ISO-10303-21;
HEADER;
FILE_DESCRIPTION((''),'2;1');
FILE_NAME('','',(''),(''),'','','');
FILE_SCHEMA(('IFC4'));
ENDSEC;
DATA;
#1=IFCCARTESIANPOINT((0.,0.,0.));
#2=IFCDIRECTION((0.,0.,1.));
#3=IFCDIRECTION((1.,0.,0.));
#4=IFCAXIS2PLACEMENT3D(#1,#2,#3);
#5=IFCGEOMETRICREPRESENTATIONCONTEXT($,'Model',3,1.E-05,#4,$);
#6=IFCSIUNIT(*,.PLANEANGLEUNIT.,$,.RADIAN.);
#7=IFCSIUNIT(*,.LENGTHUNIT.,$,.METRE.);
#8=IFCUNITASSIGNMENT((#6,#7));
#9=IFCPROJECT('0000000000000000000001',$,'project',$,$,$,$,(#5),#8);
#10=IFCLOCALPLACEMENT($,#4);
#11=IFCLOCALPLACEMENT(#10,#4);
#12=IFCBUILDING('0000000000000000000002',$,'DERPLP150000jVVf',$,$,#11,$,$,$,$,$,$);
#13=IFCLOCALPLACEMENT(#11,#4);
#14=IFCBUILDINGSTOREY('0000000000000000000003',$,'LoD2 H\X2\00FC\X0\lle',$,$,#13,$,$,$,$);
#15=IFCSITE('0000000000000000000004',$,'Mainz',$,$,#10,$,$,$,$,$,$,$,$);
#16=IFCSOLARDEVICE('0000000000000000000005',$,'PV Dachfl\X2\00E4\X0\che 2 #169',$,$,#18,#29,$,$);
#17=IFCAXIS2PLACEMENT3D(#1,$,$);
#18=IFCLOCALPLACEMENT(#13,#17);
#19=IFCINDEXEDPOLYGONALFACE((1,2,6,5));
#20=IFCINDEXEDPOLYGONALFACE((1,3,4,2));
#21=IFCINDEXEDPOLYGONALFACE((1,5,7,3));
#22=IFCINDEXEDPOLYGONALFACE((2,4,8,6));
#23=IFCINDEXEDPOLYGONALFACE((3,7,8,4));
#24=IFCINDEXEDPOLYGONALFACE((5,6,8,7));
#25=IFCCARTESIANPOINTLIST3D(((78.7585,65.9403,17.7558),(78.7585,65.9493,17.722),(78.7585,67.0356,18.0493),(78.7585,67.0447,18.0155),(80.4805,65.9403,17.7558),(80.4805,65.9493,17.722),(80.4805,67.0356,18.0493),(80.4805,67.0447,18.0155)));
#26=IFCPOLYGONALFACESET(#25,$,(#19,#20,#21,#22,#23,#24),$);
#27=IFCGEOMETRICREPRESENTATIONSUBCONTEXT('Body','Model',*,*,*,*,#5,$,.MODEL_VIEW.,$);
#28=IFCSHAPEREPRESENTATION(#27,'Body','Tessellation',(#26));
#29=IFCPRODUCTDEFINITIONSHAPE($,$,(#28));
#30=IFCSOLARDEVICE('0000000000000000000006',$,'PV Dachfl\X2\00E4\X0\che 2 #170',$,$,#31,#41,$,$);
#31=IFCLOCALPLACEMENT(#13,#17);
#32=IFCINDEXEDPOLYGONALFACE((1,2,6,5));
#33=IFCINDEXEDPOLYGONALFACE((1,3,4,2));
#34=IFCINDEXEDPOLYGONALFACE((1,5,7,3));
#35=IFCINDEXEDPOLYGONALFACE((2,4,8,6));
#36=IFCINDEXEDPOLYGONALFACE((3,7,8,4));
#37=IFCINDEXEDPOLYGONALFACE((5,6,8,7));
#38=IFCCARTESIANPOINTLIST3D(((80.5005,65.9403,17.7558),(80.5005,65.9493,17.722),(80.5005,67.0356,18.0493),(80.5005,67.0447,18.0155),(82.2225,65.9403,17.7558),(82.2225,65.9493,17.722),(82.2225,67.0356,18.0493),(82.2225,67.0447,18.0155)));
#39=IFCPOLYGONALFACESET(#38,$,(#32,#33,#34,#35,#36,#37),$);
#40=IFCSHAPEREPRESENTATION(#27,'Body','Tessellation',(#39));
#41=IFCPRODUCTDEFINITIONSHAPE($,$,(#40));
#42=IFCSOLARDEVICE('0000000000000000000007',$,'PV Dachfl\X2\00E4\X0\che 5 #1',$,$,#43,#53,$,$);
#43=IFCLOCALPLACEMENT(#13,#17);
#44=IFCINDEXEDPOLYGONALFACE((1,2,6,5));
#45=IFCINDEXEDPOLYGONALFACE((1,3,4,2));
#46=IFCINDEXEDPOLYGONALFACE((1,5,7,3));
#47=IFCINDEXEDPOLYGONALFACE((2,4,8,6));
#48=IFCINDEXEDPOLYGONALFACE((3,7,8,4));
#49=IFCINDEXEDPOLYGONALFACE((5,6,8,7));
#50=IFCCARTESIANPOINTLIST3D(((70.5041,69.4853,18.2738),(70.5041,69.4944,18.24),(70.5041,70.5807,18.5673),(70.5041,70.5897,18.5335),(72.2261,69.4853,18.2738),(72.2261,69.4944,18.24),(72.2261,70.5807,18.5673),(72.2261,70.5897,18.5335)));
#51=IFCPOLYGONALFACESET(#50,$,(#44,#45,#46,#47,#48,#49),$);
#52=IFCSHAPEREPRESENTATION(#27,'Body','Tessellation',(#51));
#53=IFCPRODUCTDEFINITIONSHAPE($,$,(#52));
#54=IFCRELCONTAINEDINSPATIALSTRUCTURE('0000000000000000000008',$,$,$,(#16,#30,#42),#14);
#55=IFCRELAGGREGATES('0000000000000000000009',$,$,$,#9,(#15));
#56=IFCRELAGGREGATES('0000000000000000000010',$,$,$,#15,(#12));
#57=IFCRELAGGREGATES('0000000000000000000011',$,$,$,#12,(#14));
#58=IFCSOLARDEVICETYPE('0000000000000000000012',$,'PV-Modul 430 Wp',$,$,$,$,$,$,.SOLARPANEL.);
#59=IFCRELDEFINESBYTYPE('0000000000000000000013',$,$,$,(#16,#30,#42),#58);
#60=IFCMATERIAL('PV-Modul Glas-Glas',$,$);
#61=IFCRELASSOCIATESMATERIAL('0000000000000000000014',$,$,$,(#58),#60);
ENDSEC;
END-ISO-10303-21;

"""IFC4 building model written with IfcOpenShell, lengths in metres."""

from ifc_helpers import new_model, si_unit, frame, frame_2d, origin, origin_with_axes, place, context, subcontext, project, spatial, rectangle, extrude, source, transform, mapped, material, type_object, type_shapes, element, save


model = new_model("IFC4")

# Units and contexts
model_context = context("Model", 3, precision=1e-05, world=origin_with_axes())
body_context = subcontext(model_context, "Body", "Model", "MODEL_VIEW")
ifc_project = project(units=[si_unit("PLANEANGLEUNIT", "RADIAN"), si_unit("LENGTHUNIT", "METRE")], contexts=[model_context])

# Site, building, storey
site_placement = place(None, origin_with_axes())
site = spatial("IfcSite", under=ifc_project, at=site_placement, Name="Mainz")
building_placement = place(site_placement, origin_with_axes())
building = spatial("IfcBuilding", under=site, at=building_placement, Name="DERPLP150000jVVf")
storey_placement = place(building_placement, origin_with_axes())
storey = spatial("IfcBuildingStorey", under=building, at=storey_placement, Name="LoD2 Hülle")

# Solar devices
ifc_material = material(Name="PV-Modul Glas-Glas")
solar_device_type = type_object("IfcSolarDeviceType", Name="PV-Modul 430 Wp", PredefinedType="SOLARPANEL", material=ifc_material)
shared_shape = source(origin_with_axes(), body_context, "Body", "SweptSolid", [
    extrude(rectangle(XDim=1.722, YDim=1.134, at=frame_2d((0.861, 0.567))), origin(), (0.0, 0.0, 1.0), 0.035),
])
type_shapes(solar_device_type, [shared_shape])
for number, where, z_axis, x_axis, name in (
    (1, (78.7585, 65.9493, 17.722), (0.0, -0.258819, 0.965926), (1.0, 0.0, 0.0), "PV Dachfläche 2 #169"),
    (2, (80.5005, 65.9493, 17.722), (0.0, -0.258819, 0.965926), (1.0, 0.0, 0.0), "PV Dachfläche 2 #170"),
    (3, (70.5041, 69.4944, 18.24), (0.0, -0.258819, 0.965926), (1.0, 0.0, 0.0), "PV Dachfläche 5 #1"),
):
    element("IfcSolarDevice", number, at=place(storey_placement, frame(where, z_axis=z_axis, x_axis=x_axis)), inside=storey, type_object=solar_device_type, Name=name, context=body_context, shape_type="MappedRepresentation", body=[
        mapped(shared_shape, transform((0.0, 0.0, 0.0), x_axis=(1.0, 0.0, 0.0), y_axis=(0.0, 1.0, 0.0), z_axis=(0.0, 0.0, 1.0), scale=1.0)),
    ])

save(model, "model.ifc")
